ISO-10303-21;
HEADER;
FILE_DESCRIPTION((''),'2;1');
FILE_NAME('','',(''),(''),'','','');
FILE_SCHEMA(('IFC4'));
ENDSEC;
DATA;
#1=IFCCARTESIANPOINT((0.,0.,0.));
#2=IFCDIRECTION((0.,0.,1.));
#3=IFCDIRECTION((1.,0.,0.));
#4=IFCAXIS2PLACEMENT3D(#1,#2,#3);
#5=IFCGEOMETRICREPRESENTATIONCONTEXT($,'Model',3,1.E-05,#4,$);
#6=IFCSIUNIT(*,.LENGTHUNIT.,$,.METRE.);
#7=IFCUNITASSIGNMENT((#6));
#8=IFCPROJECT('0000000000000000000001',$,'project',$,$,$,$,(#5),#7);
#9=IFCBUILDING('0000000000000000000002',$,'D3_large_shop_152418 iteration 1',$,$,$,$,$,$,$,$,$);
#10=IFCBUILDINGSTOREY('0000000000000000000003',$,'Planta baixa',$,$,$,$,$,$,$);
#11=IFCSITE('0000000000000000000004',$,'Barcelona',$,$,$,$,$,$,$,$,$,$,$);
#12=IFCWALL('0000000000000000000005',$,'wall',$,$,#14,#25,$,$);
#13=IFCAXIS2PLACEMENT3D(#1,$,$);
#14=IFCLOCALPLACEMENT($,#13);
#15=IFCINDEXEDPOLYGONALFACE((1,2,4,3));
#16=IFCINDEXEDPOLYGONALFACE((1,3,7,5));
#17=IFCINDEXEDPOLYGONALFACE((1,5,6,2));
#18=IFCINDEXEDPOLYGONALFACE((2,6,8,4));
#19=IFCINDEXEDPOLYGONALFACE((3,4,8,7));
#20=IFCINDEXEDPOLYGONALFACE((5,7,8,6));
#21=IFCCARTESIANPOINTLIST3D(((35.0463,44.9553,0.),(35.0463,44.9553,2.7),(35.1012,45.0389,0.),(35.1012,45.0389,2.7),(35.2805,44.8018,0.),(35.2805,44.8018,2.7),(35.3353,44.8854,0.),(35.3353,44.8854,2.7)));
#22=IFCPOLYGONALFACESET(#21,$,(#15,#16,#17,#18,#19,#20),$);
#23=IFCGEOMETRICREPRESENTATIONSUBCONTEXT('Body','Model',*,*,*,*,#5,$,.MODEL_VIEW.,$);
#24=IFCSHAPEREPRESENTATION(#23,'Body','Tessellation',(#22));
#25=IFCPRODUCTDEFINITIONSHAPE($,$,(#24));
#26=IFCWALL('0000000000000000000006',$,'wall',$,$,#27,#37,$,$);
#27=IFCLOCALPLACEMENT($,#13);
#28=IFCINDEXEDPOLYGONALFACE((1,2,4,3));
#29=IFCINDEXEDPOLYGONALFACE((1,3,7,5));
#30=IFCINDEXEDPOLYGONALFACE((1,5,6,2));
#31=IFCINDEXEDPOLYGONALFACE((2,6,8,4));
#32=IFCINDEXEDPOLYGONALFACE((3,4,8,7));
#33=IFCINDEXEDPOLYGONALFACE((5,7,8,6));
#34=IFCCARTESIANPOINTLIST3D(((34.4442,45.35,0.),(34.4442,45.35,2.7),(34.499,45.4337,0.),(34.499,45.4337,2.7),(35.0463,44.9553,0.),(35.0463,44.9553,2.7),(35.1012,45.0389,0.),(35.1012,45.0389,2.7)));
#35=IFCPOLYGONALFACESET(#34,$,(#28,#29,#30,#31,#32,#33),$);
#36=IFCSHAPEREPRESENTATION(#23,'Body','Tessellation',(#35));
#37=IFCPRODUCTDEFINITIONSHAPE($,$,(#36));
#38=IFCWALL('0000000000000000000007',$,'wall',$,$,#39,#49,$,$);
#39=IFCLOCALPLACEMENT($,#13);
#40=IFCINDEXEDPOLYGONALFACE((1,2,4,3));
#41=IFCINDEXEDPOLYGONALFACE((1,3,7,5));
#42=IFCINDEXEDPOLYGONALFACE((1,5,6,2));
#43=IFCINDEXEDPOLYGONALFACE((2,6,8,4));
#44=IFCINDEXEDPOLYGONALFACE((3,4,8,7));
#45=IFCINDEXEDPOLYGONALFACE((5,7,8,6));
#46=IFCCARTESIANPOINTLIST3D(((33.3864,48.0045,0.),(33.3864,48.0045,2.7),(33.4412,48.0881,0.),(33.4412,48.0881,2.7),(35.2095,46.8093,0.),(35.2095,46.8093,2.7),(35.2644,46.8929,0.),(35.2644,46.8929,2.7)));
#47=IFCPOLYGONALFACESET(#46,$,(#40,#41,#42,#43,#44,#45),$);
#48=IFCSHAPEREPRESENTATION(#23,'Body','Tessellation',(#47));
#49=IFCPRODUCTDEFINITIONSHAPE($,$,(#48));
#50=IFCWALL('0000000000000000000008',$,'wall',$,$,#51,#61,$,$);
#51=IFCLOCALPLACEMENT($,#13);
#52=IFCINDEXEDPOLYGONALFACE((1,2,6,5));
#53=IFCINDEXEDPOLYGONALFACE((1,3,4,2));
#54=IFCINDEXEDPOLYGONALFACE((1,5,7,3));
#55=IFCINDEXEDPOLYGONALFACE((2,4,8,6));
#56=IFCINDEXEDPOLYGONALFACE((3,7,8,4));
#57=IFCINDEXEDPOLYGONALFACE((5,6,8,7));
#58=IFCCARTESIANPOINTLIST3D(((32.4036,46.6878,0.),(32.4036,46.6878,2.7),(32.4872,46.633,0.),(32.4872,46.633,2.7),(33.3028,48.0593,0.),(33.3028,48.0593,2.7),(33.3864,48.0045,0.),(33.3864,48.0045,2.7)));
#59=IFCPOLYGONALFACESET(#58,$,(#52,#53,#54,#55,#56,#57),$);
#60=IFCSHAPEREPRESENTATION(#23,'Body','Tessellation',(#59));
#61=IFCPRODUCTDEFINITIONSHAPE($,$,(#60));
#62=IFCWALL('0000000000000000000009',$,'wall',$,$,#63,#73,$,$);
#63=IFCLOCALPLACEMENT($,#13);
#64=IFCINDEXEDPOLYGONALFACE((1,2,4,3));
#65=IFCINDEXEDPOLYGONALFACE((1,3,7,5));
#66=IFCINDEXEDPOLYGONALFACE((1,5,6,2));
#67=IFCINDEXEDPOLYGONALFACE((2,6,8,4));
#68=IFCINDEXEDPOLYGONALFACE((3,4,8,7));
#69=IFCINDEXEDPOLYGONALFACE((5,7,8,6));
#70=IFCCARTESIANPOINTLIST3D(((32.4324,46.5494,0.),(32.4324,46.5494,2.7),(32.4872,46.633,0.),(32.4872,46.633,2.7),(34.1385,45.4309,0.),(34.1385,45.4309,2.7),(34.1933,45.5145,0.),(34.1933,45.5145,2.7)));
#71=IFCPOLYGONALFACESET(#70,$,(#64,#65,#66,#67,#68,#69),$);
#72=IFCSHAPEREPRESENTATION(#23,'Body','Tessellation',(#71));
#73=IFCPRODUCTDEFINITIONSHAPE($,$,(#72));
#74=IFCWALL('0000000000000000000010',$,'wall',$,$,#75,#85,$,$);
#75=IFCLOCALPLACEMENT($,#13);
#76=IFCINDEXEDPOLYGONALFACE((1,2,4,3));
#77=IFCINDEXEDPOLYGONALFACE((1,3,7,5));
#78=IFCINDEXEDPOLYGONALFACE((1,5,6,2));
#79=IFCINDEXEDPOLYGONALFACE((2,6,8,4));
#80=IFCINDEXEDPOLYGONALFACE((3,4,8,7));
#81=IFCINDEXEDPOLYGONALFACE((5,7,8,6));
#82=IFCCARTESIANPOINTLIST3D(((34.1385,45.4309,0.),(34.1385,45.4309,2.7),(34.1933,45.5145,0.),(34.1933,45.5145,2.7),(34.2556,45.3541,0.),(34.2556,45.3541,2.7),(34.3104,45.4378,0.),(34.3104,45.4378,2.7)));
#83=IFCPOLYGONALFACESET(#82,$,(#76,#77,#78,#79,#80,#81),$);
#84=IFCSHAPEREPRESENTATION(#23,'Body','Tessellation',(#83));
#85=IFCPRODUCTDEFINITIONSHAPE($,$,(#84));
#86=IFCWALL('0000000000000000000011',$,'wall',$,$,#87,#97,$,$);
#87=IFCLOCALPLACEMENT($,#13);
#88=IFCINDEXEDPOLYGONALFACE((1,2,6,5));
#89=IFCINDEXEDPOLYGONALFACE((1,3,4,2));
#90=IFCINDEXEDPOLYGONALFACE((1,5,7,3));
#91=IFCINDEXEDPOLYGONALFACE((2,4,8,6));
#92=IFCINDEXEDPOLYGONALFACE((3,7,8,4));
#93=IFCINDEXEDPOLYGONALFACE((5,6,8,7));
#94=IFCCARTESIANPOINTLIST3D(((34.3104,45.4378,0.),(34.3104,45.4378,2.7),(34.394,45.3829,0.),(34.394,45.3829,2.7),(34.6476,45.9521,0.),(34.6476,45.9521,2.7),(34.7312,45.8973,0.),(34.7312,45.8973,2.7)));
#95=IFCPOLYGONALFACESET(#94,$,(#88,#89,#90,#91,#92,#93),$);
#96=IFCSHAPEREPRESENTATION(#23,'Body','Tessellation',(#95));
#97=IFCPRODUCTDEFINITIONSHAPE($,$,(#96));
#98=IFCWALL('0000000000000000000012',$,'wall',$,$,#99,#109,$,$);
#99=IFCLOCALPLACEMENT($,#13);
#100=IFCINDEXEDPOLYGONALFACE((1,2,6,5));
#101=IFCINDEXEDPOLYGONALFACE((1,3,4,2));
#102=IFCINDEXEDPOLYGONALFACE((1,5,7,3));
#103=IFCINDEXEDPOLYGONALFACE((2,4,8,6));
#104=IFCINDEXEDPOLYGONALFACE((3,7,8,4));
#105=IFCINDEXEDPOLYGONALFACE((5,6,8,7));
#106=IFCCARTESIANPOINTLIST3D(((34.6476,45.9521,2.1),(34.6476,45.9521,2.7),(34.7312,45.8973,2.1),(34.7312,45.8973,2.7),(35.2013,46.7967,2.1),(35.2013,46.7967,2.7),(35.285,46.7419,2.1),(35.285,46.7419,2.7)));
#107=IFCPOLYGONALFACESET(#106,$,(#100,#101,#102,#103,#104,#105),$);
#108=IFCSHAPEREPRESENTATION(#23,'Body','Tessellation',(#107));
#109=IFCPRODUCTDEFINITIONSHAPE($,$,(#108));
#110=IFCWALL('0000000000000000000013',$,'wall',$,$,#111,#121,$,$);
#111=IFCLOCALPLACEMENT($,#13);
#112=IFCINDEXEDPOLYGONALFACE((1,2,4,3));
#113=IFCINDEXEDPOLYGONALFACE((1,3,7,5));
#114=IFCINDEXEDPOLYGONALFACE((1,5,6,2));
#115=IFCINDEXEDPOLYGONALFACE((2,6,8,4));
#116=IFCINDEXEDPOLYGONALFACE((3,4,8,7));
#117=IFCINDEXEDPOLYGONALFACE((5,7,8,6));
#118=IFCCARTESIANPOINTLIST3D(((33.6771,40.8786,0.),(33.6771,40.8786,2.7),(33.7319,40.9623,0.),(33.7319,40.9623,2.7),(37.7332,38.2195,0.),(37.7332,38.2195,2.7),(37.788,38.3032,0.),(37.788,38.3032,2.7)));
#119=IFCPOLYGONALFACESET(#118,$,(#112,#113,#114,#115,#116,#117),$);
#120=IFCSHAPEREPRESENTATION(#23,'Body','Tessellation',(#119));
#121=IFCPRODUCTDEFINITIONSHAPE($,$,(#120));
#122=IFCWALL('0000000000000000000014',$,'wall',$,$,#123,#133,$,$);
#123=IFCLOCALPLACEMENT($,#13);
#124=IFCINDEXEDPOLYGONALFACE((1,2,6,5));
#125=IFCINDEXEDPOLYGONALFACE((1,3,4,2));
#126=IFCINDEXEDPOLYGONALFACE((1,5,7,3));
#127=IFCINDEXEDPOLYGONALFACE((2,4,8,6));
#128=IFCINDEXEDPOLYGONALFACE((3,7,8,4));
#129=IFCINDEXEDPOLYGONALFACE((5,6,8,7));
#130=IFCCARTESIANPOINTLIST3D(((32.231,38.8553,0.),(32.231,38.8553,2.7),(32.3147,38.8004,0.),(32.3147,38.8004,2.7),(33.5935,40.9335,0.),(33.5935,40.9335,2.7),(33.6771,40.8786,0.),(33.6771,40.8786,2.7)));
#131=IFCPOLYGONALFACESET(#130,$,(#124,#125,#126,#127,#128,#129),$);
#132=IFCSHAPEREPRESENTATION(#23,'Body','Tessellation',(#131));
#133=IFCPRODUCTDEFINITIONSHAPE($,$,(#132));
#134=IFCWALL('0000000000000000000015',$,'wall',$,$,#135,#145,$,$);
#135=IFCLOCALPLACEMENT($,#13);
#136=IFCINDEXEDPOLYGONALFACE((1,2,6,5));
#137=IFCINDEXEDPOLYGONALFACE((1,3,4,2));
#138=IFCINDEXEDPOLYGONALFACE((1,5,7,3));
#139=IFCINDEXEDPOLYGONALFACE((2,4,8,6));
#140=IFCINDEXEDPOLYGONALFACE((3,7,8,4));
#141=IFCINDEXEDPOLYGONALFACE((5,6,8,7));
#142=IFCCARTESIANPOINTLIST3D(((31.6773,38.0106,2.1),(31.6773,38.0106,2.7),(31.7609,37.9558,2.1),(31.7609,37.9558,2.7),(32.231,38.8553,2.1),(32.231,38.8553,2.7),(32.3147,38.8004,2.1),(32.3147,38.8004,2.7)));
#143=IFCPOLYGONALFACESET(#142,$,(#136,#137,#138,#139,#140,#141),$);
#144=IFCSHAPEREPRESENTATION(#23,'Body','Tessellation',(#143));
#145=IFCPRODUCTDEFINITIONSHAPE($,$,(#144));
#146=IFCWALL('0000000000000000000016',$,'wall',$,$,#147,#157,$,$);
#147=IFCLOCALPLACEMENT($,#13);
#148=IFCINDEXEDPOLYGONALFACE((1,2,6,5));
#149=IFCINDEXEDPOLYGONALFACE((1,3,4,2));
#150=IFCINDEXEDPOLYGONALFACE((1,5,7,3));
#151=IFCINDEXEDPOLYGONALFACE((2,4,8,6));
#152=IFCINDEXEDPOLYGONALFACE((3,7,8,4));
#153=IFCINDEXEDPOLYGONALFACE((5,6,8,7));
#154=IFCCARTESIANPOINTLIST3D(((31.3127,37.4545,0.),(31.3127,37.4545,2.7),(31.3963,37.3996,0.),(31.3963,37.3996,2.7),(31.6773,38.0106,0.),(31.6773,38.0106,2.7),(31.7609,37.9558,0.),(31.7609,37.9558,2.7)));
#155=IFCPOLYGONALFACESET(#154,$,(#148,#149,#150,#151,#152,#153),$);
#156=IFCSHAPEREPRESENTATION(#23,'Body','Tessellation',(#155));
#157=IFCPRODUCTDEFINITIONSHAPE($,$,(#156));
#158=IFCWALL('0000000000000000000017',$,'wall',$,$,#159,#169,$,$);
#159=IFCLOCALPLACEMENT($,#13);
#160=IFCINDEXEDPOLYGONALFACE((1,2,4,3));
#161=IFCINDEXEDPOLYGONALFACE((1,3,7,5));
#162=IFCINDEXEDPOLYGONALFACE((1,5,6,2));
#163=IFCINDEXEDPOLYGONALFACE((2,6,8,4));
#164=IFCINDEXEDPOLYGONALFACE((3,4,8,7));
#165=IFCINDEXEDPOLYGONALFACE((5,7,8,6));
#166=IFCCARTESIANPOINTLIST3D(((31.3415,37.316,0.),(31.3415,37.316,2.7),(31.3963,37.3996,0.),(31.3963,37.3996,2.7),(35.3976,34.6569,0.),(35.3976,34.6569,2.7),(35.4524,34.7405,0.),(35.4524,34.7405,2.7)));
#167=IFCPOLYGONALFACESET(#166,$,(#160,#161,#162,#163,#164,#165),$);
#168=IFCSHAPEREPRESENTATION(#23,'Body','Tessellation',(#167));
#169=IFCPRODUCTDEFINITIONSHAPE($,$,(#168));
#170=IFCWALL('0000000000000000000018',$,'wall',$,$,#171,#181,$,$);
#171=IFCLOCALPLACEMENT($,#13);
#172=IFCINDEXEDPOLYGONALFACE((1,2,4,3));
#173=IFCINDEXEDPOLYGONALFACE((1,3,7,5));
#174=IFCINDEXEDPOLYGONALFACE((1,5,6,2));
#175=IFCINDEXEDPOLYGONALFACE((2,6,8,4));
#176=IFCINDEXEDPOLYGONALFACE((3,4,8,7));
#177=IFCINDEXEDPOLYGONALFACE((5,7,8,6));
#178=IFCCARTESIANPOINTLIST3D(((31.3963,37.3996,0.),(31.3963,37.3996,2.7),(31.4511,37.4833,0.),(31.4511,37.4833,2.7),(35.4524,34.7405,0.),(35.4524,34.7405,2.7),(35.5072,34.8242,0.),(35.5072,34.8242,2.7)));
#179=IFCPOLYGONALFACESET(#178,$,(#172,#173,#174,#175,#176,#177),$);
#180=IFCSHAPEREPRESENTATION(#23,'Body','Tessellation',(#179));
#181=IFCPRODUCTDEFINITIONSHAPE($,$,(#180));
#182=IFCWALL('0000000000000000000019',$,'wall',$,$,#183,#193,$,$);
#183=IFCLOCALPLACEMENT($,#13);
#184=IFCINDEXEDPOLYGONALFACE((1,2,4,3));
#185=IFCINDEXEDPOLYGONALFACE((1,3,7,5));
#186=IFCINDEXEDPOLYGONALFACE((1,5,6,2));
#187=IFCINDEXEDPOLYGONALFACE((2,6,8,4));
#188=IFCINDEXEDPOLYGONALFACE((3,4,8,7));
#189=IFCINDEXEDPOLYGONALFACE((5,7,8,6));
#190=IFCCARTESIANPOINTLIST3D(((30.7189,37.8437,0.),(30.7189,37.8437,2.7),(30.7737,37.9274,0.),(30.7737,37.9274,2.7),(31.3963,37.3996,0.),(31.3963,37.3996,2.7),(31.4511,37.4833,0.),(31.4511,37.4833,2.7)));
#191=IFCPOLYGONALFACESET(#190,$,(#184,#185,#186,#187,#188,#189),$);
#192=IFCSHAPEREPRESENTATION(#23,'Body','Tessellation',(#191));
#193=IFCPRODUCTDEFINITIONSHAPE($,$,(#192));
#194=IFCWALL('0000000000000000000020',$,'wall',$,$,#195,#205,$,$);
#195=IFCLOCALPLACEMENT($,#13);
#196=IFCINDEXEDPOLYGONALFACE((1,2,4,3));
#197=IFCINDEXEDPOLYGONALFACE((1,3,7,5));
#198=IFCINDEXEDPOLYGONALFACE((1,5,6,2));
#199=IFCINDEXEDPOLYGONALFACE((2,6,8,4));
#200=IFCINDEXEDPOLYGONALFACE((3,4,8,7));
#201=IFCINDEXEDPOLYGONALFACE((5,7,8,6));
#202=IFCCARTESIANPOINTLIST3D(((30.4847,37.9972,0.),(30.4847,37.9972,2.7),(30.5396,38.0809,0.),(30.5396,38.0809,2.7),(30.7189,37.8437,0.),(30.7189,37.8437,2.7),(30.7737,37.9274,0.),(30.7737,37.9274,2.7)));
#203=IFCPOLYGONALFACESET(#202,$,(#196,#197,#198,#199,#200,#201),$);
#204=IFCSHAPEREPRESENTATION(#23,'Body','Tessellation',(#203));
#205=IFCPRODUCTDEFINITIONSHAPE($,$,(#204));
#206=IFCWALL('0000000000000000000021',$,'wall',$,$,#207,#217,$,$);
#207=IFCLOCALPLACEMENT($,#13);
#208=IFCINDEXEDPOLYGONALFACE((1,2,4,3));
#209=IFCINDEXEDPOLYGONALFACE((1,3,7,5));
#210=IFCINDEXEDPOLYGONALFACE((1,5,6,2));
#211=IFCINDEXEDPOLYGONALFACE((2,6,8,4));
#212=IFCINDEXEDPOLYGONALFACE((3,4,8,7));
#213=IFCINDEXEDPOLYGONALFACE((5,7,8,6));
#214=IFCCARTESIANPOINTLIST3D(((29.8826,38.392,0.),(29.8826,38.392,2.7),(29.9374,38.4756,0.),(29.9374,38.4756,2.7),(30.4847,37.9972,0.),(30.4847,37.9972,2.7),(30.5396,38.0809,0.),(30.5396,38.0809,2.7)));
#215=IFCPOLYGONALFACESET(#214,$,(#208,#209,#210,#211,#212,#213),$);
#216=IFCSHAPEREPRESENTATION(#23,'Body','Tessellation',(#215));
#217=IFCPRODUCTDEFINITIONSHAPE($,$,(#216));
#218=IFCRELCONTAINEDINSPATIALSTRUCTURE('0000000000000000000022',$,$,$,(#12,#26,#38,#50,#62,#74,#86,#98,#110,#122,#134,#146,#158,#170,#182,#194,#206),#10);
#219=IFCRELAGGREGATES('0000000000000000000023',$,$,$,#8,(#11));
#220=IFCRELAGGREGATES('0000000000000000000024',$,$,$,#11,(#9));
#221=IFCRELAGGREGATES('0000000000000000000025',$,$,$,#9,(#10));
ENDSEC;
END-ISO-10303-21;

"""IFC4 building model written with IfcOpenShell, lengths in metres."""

from ifc_helpers import new_model, si_unit, frame, origin, origin_with_axes, place, context, subcontext, project, spatial, polyline, outline, extrude, element, save


model = new_model("IFC4")

# Units and contexts
model_context = context("Model", 3, precision=1e-05, world=origin_with_axes())
body_context = subcontext(model_context, "Body", "Model", "MODEL_VIEW")
ifc_project = project(units=[si_unit("LENGTHUNIT", "METRE")], contexts=[model_context])

# Site, building, storey
site = spatial("IfcSite", under=ifc_project, Name="Barcelona")
building = spatial("IfcBuilding", under=site, Name="D3_large_shop_152418 iteration 1")
storey = spatial("IfcBuildingStorey", under=building, Name="Planta baixa")

# Walls
wall_1_placement = place(None, origin_with_axes())
element("IfcWall", 1, at=wall_1_placement, inside=storey, Name="wall", context=body_context, shape_type="SweptSolid", body=[
    extrude(outline(polyline([(35.2805, 44.8018), (35.0463, 44.9553), (35.1012, 45.0389), (35.3353, 44.8854), (35.2805, 44.8018)])), origin(), (0.0, 0.0, 1.0), 2.7),
])
wall_2_placement = place(None, origin_with_axes())
element("IfcWall", 2, at=wall_2_placement, inside=storey, Name="wall", context=body_context, shape_type="SweptSolid", body=[
    extrude(outline(polyline([(35.0463, 44.9553), (34.4442, 45.35), (34.499, 45.4337), (35.1012, 45.0389), (35.0463, 44.9553)])), origin(), (0.0, 0.0, 1.0), 2.7),
])
wall_3_placement = place(None, origin_with_axes())
element("IfcWall", 3, at=wall_3_placement, inside=storey, Name="wall", context=body_context, shape_type="SweptSolid", body=[
    extrude(outline(polyline([(35.2095, 46.8093), (33.3864, 48.0045), (33.4412, 48.0881), (35.2644, 46.8929), (35.2095, 46.8093)])), origin(), (0.0, 0.0, 1.0), 2.7),
])
wall_4_placement = place(None, origin_with_axes())
element("IfcWall", 4, at=wall_4_placement, inside=storey, Name="wall", context=body_context, shape_type="SweptSolid", body=[
    extrude(outline(polyline([(33.3864, 48.0045), (32.4872, 46.633), (32.4036, 46.6878), (33.3028, 48.0593), (33.3864, 48.0045)])), origin(), (0.0, 0.0, 1.0), 2.7),
])
wall_5_placement = place(None, origin_with_axes())
element("IfcWall", 5, at=wall_5_placement, inside=storey, Name="wall", context=body_context, shape_type="SweptSolid", body=[
    extrude(outline(polyline([(32.4872, 46.633), (34.1933, 45.5145), (34.1385, 45.4309), (32.4324, 46.5494), (32.4872, 46.633)])), origin(), (0.0, 0.0, 1.0), 2.7),
])
wall_6_placement = place(None, origin_with_axes())
element("IfcWall", 6, at=wall_6_placement, inside=storey, Name="wall", context=body_context, shape_type="SweptSolid", body=[
    extrude(outline(polyline([(34.1933, 45.5145), (34.3104, 45.4378), (34.2556, 45.3541), (34.1385, 45.4309), (34.1933, 45.5145)])), origin(), (0.0, 0.0, 1.0), 2.7),
])
wall_7_placement = place(None, origin_with_axes())
element("IfcWall", 7, at=wall_7_placement, inside=storey, Name="wall", context=body_context, shape_type="SweptSolid", body=[
    extrude(outline(polyline([(34.3104, 45.4378), (34.6476, 45.9521), (34.7312, 45.8973), (34.394, 45.3829), (34.3104, 45.4378)])), origin(), (0.0, 0.0, 1.0), 2.7),
])
wall_8_placement = place(None, origin_with_axes())
element("IfcWall", 8, at=wall_8_placement, inside=storey, Name="wall", context=body_context, shape_type="SweptSolid", body=[
    extrude(outline(polyline([(34.6476, 45.9521), (35.2013, 46.7967), (35.285, 46.7419), (34.7312, 45.8973), (34.6476, 45.9521)])), frame((0.0, 0.0, 2.1)), (0.0, 0.0, 1.0), 0.6),
])
wall_9_placement = place(None, origin_with_axes())
element("IfcWall", 9, at=wall_9_placement, inside=storey, Name="wall", context=body_context, shape_type="SweptSolid", body=[
    extrude(outline(polyline([(37.7332, 38.2195), (33.6771, 40.8786), (33.7319, 40.9623), (37.788, 38.3032), (37.7332, 38.2195)])), origin(), (0.0, 0.0, 1.0), 2.7),
])
wall_10_placement = place(None, origin_with_axes())
element("IfcWall", 10, at=wall_10_placement, inside=storey, Name="wall", context=body_context, shape_type="SweptSolid", body=[
    extrude(outline(polyline([(33.6771, 40.8786), (32.3147, 38.8004), (32.231, 38.8553), (33.5935, 40.9335), (33.6771, 40.8786)])), origin(), (0.0, 0.0, 1.0), 2.7),
])
wall_11_placement = place(None, origin_with_axes())
element("IfcWall", 11, at=wall_11_placement, inside=storey, Name="wall", context=body_context, shape_type="SweptSolid", body=[
    extrude(outline(polyline([(32.3147, 38.8004), (31.7609, 37.9558), (31.6773, 38.0106), (32.231, 38.8553), (32.3147, 38.8004)])), frame((0.0, 0.0, 2.1)), (0.0, 0.0, 1.0), 0.6),
])
wall_12_placement = place(None, origin_with_axes())
element("IfcWall", 12, at=wall_12_placement, inside=storey, Name="wall", context=body_context, shape_type="SweptSolid", body=[
    extrude(outline(polyline([(31.7609, 37.9558), (31.3963, 37.3996), (31.3127, 37.4545), (31.6773, 38.0106), (31.7609, 37.9558)])), origin(), (0.0, 0.0, 1.0), 2.7),
])
wall_13_placement = place(None, origin_with_axes())
element("IfcWall", 13, at=wall_13_placement, inside=storey, Name="wall", context=body_context, shape_type="SweptSolid", body=[
    extrude(outline(polyline([(31.3963, 37.3996), (35.4524, 34.7405), (35.3976, 34.6569), (31.3415, 37.316), (31.3963, 37.3996)])), origin(), (0.0, 0.0, 1.0), 2.7),
])
wall_14_placement = place(None, origin_with_axes())
element("IfcWall", 14, at=wall_14_placement, inside=storey, Name="wall", context=body_context, shape_type="SweptSolid", body=[
    extrude(outline(polyline([(35.4524, 34.7405), (31.3963, 37.3996), (31.4511, 37.4833), (35.5072, 34.8242), (35.4524, 34.7405)])), origin(), (0.0, 0.0, 1.0), 2.7),
])
wall_15_placement = place(None, origin_with_axes())
element("IfcWall", 15, at=wall_15_placement, inside=storey, Name="wall", context=body_context, shape_type="SweptSolid", body=[
    extrude(outline(polyline([(31.3963, 37.3996), (30.7189, 37.8437), (30.7737, 37.9274), (31.4511, 37.4833), (31.3963, 37.3996)])), origin(), (0.0, 0.0, 1.0), 2.7),
])
wall_16_placement = place(None, origin_with_axes())
element("IfcWall", 16, at=wall_16_placement, inside=storey, Name="wall", context=body_context, shape_type="SweptSolid", body=[
    extrude(outline(polyline([(30.7189, 37.8437), (30.4847, 37.9972), (30.5396, 38.0809), (30.7737, 37.9274), (30.7189, 37.8437)])), origin(), (0.0, 0.0, 1.0), 2.7),
])
wall_17_placement = place(None, origin_with_axes())
element("IfcWall", 17, at=wall_17_placement, inside=storey, Name="wall", context=body_context, shape_type="SweptSolid", body=[
    extrude(outline(polyline([(30.4847, 37.9972), (29.8826, 38.392), (29.9374, 38.4756), (30.5396, 38.0809), (30.4847, 37.9972)])), origin(), (0.0, 0.0, 1.0), 2.7),
])

save(model, "model.ifc")
